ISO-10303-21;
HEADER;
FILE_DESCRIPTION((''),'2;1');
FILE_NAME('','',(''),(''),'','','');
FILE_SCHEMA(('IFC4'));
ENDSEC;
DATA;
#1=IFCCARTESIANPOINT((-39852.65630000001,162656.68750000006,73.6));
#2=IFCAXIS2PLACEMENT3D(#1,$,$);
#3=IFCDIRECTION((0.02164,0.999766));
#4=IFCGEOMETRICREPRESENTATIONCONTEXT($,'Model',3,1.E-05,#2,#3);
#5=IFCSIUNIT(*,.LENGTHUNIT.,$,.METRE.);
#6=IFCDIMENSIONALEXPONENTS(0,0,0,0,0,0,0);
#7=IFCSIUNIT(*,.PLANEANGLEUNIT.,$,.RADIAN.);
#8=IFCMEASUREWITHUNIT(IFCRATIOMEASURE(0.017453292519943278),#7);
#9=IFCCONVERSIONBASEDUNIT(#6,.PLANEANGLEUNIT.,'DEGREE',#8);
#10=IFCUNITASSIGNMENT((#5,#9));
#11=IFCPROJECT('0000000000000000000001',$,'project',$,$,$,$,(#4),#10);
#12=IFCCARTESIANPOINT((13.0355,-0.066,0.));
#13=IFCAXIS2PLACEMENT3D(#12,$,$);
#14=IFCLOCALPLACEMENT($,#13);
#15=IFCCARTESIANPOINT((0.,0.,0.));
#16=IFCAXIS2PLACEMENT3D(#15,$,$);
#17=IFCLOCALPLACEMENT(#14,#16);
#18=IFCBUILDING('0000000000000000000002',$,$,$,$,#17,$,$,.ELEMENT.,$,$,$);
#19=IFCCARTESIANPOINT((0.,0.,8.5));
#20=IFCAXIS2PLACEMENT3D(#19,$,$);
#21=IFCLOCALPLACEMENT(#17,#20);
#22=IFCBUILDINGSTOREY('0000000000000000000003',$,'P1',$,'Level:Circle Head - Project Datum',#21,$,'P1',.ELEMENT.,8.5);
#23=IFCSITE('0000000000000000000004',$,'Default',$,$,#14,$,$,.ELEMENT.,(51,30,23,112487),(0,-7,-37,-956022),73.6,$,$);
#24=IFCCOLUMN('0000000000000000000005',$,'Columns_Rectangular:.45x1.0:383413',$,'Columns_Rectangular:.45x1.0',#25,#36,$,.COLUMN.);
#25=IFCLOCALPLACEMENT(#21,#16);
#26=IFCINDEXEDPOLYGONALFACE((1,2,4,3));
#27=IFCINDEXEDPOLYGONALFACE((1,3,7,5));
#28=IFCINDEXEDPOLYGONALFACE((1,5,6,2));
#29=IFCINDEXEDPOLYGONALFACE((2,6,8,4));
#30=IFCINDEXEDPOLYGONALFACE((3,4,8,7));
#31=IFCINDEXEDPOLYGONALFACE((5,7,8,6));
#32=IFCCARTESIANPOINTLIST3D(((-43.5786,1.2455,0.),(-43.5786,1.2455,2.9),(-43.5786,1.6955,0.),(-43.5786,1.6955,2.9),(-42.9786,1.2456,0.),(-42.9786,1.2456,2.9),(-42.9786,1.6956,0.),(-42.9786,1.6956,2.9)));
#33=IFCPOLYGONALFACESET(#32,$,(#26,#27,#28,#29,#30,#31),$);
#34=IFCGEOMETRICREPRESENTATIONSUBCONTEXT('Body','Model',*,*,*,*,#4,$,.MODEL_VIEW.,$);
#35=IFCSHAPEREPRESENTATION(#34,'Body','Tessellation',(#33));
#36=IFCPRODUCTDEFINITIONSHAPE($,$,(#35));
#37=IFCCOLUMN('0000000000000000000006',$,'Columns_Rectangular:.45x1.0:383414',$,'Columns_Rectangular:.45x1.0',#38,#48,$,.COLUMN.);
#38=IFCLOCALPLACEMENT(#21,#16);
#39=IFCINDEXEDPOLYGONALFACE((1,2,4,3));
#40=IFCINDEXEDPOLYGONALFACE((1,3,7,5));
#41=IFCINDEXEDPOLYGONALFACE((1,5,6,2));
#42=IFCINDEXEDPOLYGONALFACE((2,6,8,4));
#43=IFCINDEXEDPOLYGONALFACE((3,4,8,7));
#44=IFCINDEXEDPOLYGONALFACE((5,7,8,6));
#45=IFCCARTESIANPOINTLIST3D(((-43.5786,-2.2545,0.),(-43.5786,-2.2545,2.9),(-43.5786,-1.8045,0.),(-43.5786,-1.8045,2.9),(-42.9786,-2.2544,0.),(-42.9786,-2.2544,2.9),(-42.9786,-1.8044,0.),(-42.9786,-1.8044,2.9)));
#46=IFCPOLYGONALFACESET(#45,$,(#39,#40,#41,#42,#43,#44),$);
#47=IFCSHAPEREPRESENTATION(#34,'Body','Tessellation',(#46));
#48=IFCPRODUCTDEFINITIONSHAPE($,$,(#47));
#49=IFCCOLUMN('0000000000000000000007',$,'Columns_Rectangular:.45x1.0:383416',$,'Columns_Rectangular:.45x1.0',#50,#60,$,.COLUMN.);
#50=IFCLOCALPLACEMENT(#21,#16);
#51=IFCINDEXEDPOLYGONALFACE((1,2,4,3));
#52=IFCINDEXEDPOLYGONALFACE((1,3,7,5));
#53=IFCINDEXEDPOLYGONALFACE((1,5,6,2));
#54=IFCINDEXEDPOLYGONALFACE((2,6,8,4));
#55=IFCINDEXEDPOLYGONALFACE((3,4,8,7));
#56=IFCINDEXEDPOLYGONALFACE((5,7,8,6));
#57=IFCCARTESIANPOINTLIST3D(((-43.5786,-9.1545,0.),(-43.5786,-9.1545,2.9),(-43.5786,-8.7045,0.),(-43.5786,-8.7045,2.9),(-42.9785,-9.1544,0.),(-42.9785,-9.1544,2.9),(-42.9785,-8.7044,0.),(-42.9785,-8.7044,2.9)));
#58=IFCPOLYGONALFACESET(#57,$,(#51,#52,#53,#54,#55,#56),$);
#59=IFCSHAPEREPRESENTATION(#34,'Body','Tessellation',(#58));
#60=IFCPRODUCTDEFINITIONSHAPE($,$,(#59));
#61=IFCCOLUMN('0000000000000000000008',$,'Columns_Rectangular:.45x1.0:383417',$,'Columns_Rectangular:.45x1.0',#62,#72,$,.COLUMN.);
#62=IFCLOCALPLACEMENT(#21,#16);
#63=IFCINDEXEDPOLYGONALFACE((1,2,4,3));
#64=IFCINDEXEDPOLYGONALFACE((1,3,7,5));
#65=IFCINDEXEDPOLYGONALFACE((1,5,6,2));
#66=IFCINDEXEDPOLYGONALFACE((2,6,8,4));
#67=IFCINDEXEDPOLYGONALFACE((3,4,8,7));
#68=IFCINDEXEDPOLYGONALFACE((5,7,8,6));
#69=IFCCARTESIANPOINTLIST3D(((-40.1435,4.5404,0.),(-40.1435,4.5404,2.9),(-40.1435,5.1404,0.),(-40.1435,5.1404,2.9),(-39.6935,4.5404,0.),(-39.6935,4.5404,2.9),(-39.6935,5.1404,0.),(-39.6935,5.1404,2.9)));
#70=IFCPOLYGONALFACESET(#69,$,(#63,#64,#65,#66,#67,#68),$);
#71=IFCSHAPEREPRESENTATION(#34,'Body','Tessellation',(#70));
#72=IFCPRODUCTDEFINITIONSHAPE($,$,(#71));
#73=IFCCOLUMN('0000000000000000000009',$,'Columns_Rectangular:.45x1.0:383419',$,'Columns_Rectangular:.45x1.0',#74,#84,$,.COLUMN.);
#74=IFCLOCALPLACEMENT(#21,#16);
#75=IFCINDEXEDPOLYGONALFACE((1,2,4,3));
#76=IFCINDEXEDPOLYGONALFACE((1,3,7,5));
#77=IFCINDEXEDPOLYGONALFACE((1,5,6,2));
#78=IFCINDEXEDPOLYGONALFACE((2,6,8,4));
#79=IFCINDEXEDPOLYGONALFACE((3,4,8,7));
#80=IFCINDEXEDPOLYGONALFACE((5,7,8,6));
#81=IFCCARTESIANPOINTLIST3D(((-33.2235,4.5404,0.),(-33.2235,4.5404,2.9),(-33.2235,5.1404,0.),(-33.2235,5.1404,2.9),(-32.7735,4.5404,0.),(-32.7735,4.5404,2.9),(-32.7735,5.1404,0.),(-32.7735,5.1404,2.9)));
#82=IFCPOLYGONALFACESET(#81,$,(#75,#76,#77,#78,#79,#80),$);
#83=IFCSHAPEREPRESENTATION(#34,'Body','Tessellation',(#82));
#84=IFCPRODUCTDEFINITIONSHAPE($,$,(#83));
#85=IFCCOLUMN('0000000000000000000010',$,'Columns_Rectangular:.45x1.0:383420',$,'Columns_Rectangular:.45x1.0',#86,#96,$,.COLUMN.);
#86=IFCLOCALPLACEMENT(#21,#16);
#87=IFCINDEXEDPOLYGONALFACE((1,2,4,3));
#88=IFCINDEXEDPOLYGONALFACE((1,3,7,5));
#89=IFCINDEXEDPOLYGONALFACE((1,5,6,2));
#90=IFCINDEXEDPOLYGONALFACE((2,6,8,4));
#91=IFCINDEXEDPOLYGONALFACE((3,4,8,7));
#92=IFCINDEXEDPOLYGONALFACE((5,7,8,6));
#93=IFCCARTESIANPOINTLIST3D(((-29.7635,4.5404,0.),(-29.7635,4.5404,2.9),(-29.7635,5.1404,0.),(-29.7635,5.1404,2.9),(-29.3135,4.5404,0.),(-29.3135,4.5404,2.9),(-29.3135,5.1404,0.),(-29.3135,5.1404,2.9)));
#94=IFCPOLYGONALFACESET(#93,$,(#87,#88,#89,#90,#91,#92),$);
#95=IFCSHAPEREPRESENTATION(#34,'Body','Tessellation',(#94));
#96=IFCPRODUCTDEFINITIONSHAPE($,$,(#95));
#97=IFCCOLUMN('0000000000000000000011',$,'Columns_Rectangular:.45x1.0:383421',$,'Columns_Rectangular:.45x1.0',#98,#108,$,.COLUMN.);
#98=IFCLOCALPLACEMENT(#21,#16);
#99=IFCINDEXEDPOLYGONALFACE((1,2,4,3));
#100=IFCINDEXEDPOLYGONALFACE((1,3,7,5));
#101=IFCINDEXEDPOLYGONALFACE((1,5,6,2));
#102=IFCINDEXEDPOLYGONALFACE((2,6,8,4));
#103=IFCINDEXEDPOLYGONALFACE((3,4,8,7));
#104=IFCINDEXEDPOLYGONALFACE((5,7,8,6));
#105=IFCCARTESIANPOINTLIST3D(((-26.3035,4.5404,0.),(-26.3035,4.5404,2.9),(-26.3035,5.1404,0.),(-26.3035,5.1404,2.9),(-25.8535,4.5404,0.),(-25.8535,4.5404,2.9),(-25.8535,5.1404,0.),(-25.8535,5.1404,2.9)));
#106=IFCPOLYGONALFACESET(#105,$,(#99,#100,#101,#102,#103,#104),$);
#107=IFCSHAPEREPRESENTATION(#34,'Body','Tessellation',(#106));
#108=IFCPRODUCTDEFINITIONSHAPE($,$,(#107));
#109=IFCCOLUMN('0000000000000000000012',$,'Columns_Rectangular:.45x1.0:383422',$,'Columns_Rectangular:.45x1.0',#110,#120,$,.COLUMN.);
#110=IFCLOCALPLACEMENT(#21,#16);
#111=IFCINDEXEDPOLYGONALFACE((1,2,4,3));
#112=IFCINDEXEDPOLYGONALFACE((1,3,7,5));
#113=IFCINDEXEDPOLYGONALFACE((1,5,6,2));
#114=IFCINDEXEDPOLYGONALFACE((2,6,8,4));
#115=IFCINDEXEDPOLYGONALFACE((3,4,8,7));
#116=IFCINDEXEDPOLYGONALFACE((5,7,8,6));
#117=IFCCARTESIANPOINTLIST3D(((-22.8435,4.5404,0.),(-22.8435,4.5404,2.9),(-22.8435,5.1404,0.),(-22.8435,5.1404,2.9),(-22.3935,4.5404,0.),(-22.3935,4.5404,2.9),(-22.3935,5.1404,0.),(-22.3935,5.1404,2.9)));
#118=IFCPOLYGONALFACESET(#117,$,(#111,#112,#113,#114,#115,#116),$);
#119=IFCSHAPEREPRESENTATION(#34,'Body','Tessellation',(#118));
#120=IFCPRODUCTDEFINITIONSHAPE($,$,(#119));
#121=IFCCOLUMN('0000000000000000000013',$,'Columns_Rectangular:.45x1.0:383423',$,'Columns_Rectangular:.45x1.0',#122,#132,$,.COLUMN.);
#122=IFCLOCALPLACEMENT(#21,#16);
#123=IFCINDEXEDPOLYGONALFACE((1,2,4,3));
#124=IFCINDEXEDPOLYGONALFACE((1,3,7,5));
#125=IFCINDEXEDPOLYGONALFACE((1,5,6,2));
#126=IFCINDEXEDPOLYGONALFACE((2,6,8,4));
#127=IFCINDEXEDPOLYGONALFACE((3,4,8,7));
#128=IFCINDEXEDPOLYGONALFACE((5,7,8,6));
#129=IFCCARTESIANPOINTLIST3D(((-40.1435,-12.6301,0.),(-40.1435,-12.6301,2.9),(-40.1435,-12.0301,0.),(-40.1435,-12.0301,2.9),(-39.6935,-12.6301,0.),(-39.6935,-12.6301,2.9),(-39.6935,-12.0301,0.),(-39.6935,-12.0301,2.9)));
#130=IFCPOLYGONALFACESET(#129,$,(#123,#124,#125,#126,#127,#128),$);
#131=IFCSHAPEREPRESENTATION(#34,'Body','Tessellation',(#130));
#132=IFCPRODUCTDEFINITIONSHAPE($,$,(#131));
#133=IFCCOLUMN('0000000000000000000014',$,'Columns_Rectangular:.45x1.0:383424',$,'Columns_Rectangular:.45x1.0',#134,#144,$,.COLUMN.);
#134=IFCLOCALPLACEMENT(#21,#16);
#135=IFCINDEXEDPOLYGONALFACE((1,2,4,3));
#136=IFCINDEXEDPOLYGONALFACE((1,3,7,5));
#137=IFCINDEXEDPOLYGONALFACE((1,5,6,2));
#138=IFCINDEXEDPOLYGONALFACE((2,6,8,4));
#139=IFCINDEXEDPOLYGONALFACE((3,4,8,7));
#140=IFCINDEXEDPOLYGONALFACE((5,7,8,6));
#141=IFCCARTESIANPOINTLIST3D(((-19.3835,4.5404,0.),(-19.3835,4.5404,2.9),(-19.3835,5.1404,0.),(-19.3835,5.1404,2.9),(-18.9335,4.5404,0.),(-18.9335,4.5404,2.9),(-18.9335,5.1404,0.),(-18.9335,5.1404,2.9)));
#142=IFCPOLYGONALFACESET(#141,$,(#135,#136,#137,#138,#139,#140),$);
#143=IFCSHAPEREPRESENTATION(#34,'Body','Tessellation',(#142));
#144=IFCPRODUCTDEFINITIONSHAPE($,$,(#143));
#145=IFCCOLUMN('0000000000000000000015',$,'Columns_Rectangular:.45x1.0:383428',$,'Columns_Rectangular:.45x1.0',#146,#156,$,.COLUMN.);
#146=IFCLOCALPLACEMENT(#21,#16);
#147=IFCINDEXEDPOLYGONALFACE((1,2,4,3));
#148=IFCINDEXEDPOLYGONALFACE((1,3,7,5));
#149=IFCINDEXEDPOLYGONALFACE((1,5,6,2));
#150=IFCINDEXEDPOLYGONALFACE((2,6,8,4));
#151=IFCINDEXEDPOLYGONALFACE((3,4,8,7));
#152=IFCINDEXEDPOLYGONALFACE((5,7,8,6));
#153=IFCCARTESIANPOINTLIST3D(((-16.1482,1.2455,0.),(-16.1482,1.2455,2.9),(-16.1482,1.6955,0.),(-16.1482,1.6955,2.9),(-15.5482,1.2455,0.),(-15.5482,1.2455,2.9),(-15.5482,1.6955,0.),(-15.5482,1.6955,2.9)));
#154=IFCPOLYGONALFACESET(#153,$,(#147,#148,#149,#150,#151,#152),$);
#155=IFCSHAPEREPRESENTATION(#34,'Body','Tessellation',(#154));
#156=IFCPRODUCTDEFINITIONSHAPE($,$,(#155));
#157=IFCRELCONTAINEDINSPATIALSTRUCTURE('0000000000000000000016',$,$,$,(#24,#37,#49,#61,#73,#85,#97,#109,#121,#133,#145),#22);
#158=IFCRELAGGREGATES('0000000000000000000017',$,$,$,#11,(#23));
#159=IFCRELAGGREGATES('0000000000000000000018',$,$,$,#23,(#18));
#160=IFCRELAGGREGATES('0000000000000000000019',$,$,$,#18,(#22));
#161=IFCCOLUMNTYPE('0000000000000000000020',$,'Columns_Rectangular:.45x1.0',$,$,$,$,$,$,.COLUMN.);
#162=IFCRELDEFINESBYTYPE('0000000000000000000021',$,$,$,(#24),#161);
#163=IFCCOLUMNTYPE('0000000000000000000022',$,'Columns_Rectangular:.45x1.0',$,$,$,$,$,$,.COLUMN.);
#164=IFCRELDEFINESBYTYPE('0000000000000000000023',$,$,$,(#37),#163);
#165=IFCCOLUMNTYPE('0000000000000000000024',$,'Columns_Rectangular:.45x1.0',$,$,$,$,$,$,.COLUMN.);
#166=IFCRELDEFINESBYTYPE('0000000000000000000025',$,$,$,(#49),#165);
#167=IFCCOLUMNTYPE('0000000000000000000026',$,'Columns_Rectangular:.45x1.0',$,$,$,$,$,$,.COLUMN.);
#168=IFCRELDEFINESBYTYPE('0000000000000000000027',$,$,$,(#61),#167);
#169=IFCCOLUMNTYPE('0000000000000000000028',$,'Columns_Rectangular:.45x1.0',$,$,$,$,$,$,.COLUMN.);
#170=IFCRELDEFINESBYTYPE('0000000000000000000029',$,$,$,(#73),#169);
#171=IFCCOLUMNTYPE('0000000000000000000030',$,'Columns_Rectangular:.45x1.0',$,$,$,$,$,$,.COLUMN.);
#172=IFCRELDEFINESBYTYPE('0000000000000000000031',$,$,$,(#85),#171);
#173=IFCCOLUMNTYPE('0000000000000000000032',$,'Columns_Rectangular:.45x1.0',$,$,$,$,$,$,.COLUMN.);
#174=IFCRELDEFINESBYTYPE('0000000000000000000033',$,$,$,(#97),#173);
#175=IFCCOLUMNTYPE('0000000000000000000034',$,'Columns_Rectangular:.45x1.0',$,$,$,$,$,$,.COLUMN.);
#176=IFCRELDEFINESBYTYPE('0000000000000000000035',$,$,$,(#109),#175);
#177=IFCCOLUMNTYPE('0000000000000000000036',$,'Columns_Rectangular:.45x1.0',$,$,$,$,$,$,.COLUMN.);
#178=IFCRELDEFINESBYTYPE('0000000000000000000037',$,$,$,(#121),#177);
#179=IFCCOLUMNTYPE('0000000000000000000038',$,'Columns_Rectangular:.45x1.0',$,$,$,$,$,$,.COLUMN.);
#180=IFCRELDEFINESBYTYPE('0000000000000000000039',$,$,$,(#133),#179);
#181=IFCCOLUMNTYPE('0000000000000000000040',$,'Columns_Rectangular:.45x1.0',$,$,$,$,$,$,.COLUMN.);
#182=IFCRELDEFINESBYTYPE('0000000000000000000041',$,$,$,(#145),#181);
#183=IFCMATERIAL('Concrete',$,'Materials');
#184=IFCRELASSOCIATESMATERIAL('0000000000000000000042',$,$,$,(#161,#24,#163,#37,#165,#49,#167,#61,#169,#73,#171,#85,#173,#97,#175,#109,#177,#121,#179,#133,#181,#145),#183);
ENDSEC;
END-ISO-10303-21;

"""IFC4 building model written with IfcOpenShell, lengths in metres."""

from ifc_helpers import new_model, entity, si_unit, converted_unit, direction, frame, origin, place, context, subcontext, project, spatial, indexed_curve, outline, extrude, source, transform, mapped, material, type_object, type_shapes, element, save


model = new_model("IFC4")

# Units and contexts
model_context = context("Model", 3, precision=1e-05, world=frame((-39852.65630000001, 162656.68750000006, 73.6)), true_north=direction((0.02164, 0.999766)))
body_context = subcontext(model_context, "Body", "Model", "MODEL_VIEW")
ifc_project = project(units=[si_unit("LENGTHUNIT", "METRE"), converted_unit("PLANEANGLEUNIT", "DEGREE", entity("IfcRatioMeasure", 0.017453292519943278), si_unit("PLANEANGLEUNIT", "RADIAN"), dimensions=[0, 0, 0, 0, 0, 0, 0])], contexts=[model_context])

# Site, building, storey
site_placement = place(None, frame((13.0355, -0.066, 0.0)))
site = spatial("IfcSite", under=ifc_project, at=site_placement, Name="Default", CompositionType="ELEMENT", RefLatitude=(51, 30, 23, 112487), RefLongitude=(0, -7, -37, -956022), RefElevation=73.6)
building_placement = place(site_placement, origin())
building = spatial("IfcBuilding", under=site, at=building_placement, CompositionType="ELEMENT")
storey_placement = place(building_placement, frame((0.0, 0.0, 8.5)))
storey = spatial("IfcBuildingStorey", under=building, at=storey_placement, Name="P1", ObjectType="Level:Circle Head - Project Datum", LongName="P1", CompositionType="ELEMENT", Elevation=8.5)

# Columns
ifc_material = material(Name="Concrete", Category="Materials")
column_type_1 = type_object("IfcColumnType", Name="Columns_Rectangular:.45x1.0", PredefinedType="COLUMN", material=ifc_material)
shared_shape_1 = source(origin(), body_context, "Body", "SweptSolid", [
    extrude(outline(indexed_curve([(-0.3, -0.225), (0.3, -0.225), (0.3, 0.225), (-0.3, 0.225), (-0.3, -0.225)], self_intersect=False)), frame((-43.2786, 1.4706, 8.5), z_axis=(0.0, 0.0, 1.0), x_axis=(-1.0, -0.000005, 0.0)), (0.0, 0.0, 1.0), 2.9),
])
type_shapes(column_type_1, [shared_shape_1])
column_1_placement = place(storey_placement, frame((0.0, 0.0, -8.5)))
element("IfcColumn", 1, at=column_1_placement, inside=storey, type_object=column_type_1, material=ifc_material, Name="Columns_Rectangular:.45x1.0:383413", ObjectType="Columns_Rectangular:.45x1.0", PredefinedType="COLUMN", context=body_context, shape_type="MappedRepresentation", body=[
    mapped(shared_shape_1, transform((0.0, 0.0, 0.0), scale=1.0)),
])
column_type_2 = type_object("IfcColumnType", Name="Columns_Rectangular:.45x1.0", PredefinedType="COLUMN", material=ifc_material)
shared_shape_2 = source(origin(), body_context, "Body", "SweptSolid", [
    extrude(outline(indexed_curve([(-0.3, -0.225), (0.3, -0.225), (0.3, 0.225), (-0.3, 0.225), (-0.3, -0.225)], self_intersect=False)), frame((-43.2786, -2.0294, 8.5), z_axis=(0.0, 0.0, 1.0), x_axis=(-1.0, -0.000005, 0.0)), (0.0, 0.0, 1.0), 2.9),
])
type_shapes(column_type_2, [shared_shape_2])
column_2_placement = place(storey_placement, frame((0.0, 0.0, -8.5)))
element("IfcColumn", 2, at=column_2_placement, inside=storey, type_object=column_type_2, material=ifc_material, Name="Columns_Rectangular:.45x1.0:383414", ObjectType="Columns_Rectangular:.45x1.0", PredefinedType="COLUMN", context=body_context, shape_type="MappedRepresentation", body=[
    mapped(shared_shape_2, transform((0.0, 0.0, 0.0), scale=1.0)),
])
column_type_3 = type_object("IfcColumnType", Name="Columns_Rectangular:.45x1.0", PredefinedType="COLUMN", material=ifc_material)
shared_shape_3 = source(origin(), body_context, "Body", "SweptSolid", [
    extrude(outline(indexed_curve([(-0.3, -0.225), (0.3, -0.225), (0.3, 0.225), (-0.3, 0.225), (-0.3, -0.225)], self_intersect=False)), frame((-43.2785, -8.9294, 8.5), z_axis=(0.0, 0.0, 1.0), x_axis=(-1.0, -0.000005, 0.0)), (0.0, 0.0, 1.0), 2.9),
])
type_shapes(column_type_3, [shared_shape_3])
column_3_placement = place(storey_placement, frame((0.0, 0.0, -8.5)))
element("IfcColumn", 3, at=column_3_placement, inside=storey, type_object=column_type_3, material=ifc_material, Name="Columns_Rectangular:.45x1.0:383416", ObjectType="Columns_Rectangular:.45x1.0", PredefinedType="COLUMN", context=body_context, shape_type="MappedRepresentation", body=[
    mapped(shared_shape_3, transform((0.0, 0.0, 0.0), scale=1.0)),
])
column_type_4 = type_object("IfcColumnType", Name="Columns_Rectangular:.45x1.0", PredefinedType="COLUMN", material=ifc_material)
shared_shape_4 = source(origin(), body_context, "Body", "SweptSolid", [
    extrude(outline(indexed_curve([(-0.3, -0.225), (0.3, -0.225), (0.3, 0.225), (-0.3, 0.225), (-0.3, -0.225)], self_intersect=False)), frame((-39.9185, 4.8404, 8.5), z_axis=(0.0, 0.0, 1.0), x_axis=(0.0, -1.0, 0.0)), (0.0, 0.0, 1.0), 2.9),
])
type_shapes(column_type_4, [shared_shape_4])
column_4_placement = place(storey_placement, frame((0.0, 0.0, -8.5)))
element("IfcColumn", 4, at=column_4_placement, inside=storey, type_object=column_type_4, material=ifc_material, Name="Columns_Rectangular:.45x1.0:383417", ObjectType="Columns_Rectangular:.45x1.0", PredefinedType="COLUMN", context=body_context, shape_type="MappedRepresentation", body=[
    mapped(shared_shape_4, transform((0.0, 0.0, 0.0), scale=1.0)),
])
column_type_5 = type_object("IfcColumnType", Name="Columns_Rectangular:.45x1.0", PredefinedType="COLUMN", material=ifc_material)
shared_shape_5 = source(origin(), body_context, "Body", "SweptSolid", [
    extrude(outline(indexed_curve([(-0.3, -0.225), (0.3, -0.225), (0.3, 0.225), (-0.3, 0.225), (-0.3, -0.225)], self_intersect=False)), frame((-32.9985, 4.8404, 8.5), z_axis=(0.0, 0.0, 1.0), x_axis=(0.0, -1.0, 0.0)), (0.0, 0.0, 1.0), 2.9),
])
type_shapes(column_type_5, [shared_shape_5])
column_5_placement = place(storey_placement, frame((0.0, 0.0, -8.5)))
element("IfcColumn", 5, at=column_5_placement, inside=storey, type_object=column_type_5, material=ifc_material, Name="Columns_Rectangular:.45x1.0:383419", ObjectType="Columns_Rectangular:.45x1.0", PredefinedType="COLUMN", context=body_context, shape_type="MappedRepresentation", body=[
    mapped(shared_shape_5, transform((0.0, 0.0, 0.0), scale=1.0)),
])
column_type_6 = type_object("IfcColumnType", Name="Columns_Rectangular:.45x1.0", PredefinedType="COLUMN", material=ifc_material)
shared_shape_6 = source(origin(), body_context, "Body", "SweptSolid", [
    extrude(outline(indexed_curve([(-0.3, -0.225), (0.3, -0.225), (0.3, 0.225), (-0.3, 0.225), (-0.3, -0.225)], self_intersect=False)), frame((-29.5385, 4.8404, 8.5), z_axis=(0.0, 0.0, 1.0), x_axis=(0.0, -1.0, 0.0)), (0.0, 0.0, 1.0), 2.9),
])
type_shapes(column_type_6, [shared_shape_6])
column_6_placement = place(storey_placement, frame((0.0, 0.0, -8.5)))
element("IfcColumn", 6, at=column_6_placement, inside=storey, type_object=column_type_6, material=ifc_material, Name="Columns_Rectangular:.45x1.0:383420", ObjectType="Columns_Rectangular:.45x1.0", PredefinedType="COLUMN", context=body_context, shape_type="MappedRepresentation", body=[
    mapped(shared_shape_6, transform((0.0, 0.0, 0.0), scale=1.0)),
])
column_type_7 = type_object("IfcColumnType", Name="Columns_Rectangular:.45x1.0", PredefinedType="COLUMN", material=ifc_material)
shared_shape_7 = source(origin(), body_context, "Body", "SweptSolid", [
    extrude(outline(indexed_curve([(-0.3, -0.225), (0.3, -0.225), (0.3, 0.225), (-0.3, 0.225), (-0.3, -0.225)], self_intersect=False)), frame((-26.0785, 4.8404, 8.5), z_axis=(0.0, 0.0, 1.0), x_axis=(0.0, -1.0, 0.0)), (0.0, 0.0, 1.0), 2.9),
])
type_shapes(column_type_7, [shared_shape_7])
column_7_placement = place(storey_placement, frame((0.0, 0.0, -8.5)))
element("IfcColumn", 7, at=column_7_placement, inside=storey, type_object=column_type_7, material=ifc_material, Name="Columns_Rectangular:.45x1.0:383421", ObjectType="Columns_Rectangular:.45x1.0", PredefinedType="COLUMN", context=body_context, shape_type="MappedRepresentation", body=[
    mapped(shared_shape_7, transform((0.0, 0.0, 0.0), scale=1.0)),
])
column_type_8 = type_object("IfcColumnType", Name="Columns_Rectangular:.45x1.0", PredefinedType="COLUMN", material=ifc_material)
shared_shape_8 = source(origin(), body_context, "Body", "SweptSolid", [
    extrude(outline(indexed_curve([(-0.3, -0.225), (0.3, -0.225), (0.3, 0.225), (-0.3, 0.225), (-0.3, -0.225)], self_intersect=False)), frame((-22.6185, 4.8404, 8.5), z_axis=(0.0, 0.0, 1.0), x_axis=(0.0, -1.0, 0.0)), (0.0, 0.0, 1.0), 2.9),
])
type_shapes(column_type_8, [shared_shape_8])
column_8_placement = place(storey_placement, frame((0.0, 0.0, -8.5)))
element("IfcColumn", 8, at=column_8_placement, inside=storey, type_object=column_type_8, material=ifc_material, Name="Columns_Rectangular:.45x1.0:383422", ObjectType="Columns_Rectangular:.45x1.0", PredefinedType="COLUMN", context=body_context, shape_type="MappedRepresentation", body=[
    mapped(shared_shape_8, transform((0.0, 0.0, 0.0), scale=1.0)),
])
column_type_9 = type_object("IfcColumnType", Name="Columns_Rectangular:.45x1.0", PredefinedType="COLUMN", material=ifc_material)
shared_shape_9 = source(origin(), body_context, "Body", "SweptSolid", [
    extrude(outline(indexed_curve([(-0.3, -0.225), (0.3, -0.225), (0.3, 0.225), (-0.3, 0.225), (-0.3, -0.225)], self_intersect=False)), frame((-39.9185, -12.3301, 8.5), z_axis=(0.0, 0.0, 1.0), x_axis=(0.000011, 1.0, 0.0)), (0.0, 0.0, 1.0), 2.9),
])
type_shapes(column_type_9, [shared_shape_9])
column_9_placement = place(storey_placement, frame((0.0, 0.0, -8.5)))
element("IfcColumn", 9, at=column_9_placement, inside=storey, type_object=column_type_9, material=ifc_material, Name="Columns_Rectangular:.45x1.0:383423", ObjectType="Columns_Rectangular:.45x1.0", PredefinedType="COLUMN", context=body_context, shape_type="MappedRepresentation", body=[
    mapped(shared_shape_9, transform((0.0, 0.0, 0.0), scale=1.0)),
])
column_type_10 = type_object("IfcColumnType", Name="Columns_Rectangular:.45x1.0", PredefinedType="COLUMN", material=ifc_material)
shared_shape_10 = source(origin(), body_context, "Body", "SweptSolid", [
    extrude(outline(indexed_curve([(-0.3, -0.225), (0.3, -0.225), (0.3, 0.225), (-0.3, 0.225), (-0.3, -0.225)], self_intersect=False)), frame((-19.1585, 4.8404, 8.5), z_axis=(0.0, 0.0, 1.0), x_axis=(0.0, -1.0, 0.0)), (0.0, 0.0, 1.0), 2.9),
])
type_shapes(column_type_10, [shared_shape_10])
column_10_placement = place(storey_placement, frame((0.0, 0.0, -8.5)))
element("IfcColumn", 10, at=column_10_placement, inside=storey, type_object=column_type_10, material=ifc_material, Name="Columns_Rectangular:.45x1.0:383424", ObjectType="Columns_Rectangular:.45x1.0", PredefinedType="COLUMN", context=body_context, shape_type="MappedRepresentation", body=[
    mapped(shared_shape_10, transform((0.0, 0.0, 0.0), scale=1.0)),
])
column_type_11 = type_object("IfcColumnType", Name="Columns_Rectangular:.45x1.0", PredefinedType="COLUMN", material=ifc_material)
shared_shape_11 = source(origin(), body_context, "Body", "SweptSolid", [
    extrude(outline(indexed_curve([(-0.225, -0.3), (0.225, -0.3), (0.225, 0.3), (-0.225, 0.3), (-0.225, -0.3)], self_intersect=False)), frame((-15.8482, 1.4705, 8.5), z_axis=(0.0, 0.0, 1.0), x_axis=(0.0, -1.0, 0.0)), (0.0, 0.0, 1.0), 2.9),
])
type_shapes(column_type_11, [shared_shape_11])
column_11_placement = place(storey_placement, frame((0.0, 0.0, -8.5)))
element("IfcColumn", 11, at=column_11_placement, inside=storey, type_object=column_type_11, material=ifc_material, Name="Columns_Rectangular:.45x1.0:383428", ObjectType="Columns_Rectangular:.45x1.0", PredefinedType="COLUMN", context=body_context, shape_type="MappedRepresentation", body=[
    mapped(shared_shape_11, transform((0.0, 0.0, 0.0), scale=1.0)),
])

save(model, "model.ifc")
